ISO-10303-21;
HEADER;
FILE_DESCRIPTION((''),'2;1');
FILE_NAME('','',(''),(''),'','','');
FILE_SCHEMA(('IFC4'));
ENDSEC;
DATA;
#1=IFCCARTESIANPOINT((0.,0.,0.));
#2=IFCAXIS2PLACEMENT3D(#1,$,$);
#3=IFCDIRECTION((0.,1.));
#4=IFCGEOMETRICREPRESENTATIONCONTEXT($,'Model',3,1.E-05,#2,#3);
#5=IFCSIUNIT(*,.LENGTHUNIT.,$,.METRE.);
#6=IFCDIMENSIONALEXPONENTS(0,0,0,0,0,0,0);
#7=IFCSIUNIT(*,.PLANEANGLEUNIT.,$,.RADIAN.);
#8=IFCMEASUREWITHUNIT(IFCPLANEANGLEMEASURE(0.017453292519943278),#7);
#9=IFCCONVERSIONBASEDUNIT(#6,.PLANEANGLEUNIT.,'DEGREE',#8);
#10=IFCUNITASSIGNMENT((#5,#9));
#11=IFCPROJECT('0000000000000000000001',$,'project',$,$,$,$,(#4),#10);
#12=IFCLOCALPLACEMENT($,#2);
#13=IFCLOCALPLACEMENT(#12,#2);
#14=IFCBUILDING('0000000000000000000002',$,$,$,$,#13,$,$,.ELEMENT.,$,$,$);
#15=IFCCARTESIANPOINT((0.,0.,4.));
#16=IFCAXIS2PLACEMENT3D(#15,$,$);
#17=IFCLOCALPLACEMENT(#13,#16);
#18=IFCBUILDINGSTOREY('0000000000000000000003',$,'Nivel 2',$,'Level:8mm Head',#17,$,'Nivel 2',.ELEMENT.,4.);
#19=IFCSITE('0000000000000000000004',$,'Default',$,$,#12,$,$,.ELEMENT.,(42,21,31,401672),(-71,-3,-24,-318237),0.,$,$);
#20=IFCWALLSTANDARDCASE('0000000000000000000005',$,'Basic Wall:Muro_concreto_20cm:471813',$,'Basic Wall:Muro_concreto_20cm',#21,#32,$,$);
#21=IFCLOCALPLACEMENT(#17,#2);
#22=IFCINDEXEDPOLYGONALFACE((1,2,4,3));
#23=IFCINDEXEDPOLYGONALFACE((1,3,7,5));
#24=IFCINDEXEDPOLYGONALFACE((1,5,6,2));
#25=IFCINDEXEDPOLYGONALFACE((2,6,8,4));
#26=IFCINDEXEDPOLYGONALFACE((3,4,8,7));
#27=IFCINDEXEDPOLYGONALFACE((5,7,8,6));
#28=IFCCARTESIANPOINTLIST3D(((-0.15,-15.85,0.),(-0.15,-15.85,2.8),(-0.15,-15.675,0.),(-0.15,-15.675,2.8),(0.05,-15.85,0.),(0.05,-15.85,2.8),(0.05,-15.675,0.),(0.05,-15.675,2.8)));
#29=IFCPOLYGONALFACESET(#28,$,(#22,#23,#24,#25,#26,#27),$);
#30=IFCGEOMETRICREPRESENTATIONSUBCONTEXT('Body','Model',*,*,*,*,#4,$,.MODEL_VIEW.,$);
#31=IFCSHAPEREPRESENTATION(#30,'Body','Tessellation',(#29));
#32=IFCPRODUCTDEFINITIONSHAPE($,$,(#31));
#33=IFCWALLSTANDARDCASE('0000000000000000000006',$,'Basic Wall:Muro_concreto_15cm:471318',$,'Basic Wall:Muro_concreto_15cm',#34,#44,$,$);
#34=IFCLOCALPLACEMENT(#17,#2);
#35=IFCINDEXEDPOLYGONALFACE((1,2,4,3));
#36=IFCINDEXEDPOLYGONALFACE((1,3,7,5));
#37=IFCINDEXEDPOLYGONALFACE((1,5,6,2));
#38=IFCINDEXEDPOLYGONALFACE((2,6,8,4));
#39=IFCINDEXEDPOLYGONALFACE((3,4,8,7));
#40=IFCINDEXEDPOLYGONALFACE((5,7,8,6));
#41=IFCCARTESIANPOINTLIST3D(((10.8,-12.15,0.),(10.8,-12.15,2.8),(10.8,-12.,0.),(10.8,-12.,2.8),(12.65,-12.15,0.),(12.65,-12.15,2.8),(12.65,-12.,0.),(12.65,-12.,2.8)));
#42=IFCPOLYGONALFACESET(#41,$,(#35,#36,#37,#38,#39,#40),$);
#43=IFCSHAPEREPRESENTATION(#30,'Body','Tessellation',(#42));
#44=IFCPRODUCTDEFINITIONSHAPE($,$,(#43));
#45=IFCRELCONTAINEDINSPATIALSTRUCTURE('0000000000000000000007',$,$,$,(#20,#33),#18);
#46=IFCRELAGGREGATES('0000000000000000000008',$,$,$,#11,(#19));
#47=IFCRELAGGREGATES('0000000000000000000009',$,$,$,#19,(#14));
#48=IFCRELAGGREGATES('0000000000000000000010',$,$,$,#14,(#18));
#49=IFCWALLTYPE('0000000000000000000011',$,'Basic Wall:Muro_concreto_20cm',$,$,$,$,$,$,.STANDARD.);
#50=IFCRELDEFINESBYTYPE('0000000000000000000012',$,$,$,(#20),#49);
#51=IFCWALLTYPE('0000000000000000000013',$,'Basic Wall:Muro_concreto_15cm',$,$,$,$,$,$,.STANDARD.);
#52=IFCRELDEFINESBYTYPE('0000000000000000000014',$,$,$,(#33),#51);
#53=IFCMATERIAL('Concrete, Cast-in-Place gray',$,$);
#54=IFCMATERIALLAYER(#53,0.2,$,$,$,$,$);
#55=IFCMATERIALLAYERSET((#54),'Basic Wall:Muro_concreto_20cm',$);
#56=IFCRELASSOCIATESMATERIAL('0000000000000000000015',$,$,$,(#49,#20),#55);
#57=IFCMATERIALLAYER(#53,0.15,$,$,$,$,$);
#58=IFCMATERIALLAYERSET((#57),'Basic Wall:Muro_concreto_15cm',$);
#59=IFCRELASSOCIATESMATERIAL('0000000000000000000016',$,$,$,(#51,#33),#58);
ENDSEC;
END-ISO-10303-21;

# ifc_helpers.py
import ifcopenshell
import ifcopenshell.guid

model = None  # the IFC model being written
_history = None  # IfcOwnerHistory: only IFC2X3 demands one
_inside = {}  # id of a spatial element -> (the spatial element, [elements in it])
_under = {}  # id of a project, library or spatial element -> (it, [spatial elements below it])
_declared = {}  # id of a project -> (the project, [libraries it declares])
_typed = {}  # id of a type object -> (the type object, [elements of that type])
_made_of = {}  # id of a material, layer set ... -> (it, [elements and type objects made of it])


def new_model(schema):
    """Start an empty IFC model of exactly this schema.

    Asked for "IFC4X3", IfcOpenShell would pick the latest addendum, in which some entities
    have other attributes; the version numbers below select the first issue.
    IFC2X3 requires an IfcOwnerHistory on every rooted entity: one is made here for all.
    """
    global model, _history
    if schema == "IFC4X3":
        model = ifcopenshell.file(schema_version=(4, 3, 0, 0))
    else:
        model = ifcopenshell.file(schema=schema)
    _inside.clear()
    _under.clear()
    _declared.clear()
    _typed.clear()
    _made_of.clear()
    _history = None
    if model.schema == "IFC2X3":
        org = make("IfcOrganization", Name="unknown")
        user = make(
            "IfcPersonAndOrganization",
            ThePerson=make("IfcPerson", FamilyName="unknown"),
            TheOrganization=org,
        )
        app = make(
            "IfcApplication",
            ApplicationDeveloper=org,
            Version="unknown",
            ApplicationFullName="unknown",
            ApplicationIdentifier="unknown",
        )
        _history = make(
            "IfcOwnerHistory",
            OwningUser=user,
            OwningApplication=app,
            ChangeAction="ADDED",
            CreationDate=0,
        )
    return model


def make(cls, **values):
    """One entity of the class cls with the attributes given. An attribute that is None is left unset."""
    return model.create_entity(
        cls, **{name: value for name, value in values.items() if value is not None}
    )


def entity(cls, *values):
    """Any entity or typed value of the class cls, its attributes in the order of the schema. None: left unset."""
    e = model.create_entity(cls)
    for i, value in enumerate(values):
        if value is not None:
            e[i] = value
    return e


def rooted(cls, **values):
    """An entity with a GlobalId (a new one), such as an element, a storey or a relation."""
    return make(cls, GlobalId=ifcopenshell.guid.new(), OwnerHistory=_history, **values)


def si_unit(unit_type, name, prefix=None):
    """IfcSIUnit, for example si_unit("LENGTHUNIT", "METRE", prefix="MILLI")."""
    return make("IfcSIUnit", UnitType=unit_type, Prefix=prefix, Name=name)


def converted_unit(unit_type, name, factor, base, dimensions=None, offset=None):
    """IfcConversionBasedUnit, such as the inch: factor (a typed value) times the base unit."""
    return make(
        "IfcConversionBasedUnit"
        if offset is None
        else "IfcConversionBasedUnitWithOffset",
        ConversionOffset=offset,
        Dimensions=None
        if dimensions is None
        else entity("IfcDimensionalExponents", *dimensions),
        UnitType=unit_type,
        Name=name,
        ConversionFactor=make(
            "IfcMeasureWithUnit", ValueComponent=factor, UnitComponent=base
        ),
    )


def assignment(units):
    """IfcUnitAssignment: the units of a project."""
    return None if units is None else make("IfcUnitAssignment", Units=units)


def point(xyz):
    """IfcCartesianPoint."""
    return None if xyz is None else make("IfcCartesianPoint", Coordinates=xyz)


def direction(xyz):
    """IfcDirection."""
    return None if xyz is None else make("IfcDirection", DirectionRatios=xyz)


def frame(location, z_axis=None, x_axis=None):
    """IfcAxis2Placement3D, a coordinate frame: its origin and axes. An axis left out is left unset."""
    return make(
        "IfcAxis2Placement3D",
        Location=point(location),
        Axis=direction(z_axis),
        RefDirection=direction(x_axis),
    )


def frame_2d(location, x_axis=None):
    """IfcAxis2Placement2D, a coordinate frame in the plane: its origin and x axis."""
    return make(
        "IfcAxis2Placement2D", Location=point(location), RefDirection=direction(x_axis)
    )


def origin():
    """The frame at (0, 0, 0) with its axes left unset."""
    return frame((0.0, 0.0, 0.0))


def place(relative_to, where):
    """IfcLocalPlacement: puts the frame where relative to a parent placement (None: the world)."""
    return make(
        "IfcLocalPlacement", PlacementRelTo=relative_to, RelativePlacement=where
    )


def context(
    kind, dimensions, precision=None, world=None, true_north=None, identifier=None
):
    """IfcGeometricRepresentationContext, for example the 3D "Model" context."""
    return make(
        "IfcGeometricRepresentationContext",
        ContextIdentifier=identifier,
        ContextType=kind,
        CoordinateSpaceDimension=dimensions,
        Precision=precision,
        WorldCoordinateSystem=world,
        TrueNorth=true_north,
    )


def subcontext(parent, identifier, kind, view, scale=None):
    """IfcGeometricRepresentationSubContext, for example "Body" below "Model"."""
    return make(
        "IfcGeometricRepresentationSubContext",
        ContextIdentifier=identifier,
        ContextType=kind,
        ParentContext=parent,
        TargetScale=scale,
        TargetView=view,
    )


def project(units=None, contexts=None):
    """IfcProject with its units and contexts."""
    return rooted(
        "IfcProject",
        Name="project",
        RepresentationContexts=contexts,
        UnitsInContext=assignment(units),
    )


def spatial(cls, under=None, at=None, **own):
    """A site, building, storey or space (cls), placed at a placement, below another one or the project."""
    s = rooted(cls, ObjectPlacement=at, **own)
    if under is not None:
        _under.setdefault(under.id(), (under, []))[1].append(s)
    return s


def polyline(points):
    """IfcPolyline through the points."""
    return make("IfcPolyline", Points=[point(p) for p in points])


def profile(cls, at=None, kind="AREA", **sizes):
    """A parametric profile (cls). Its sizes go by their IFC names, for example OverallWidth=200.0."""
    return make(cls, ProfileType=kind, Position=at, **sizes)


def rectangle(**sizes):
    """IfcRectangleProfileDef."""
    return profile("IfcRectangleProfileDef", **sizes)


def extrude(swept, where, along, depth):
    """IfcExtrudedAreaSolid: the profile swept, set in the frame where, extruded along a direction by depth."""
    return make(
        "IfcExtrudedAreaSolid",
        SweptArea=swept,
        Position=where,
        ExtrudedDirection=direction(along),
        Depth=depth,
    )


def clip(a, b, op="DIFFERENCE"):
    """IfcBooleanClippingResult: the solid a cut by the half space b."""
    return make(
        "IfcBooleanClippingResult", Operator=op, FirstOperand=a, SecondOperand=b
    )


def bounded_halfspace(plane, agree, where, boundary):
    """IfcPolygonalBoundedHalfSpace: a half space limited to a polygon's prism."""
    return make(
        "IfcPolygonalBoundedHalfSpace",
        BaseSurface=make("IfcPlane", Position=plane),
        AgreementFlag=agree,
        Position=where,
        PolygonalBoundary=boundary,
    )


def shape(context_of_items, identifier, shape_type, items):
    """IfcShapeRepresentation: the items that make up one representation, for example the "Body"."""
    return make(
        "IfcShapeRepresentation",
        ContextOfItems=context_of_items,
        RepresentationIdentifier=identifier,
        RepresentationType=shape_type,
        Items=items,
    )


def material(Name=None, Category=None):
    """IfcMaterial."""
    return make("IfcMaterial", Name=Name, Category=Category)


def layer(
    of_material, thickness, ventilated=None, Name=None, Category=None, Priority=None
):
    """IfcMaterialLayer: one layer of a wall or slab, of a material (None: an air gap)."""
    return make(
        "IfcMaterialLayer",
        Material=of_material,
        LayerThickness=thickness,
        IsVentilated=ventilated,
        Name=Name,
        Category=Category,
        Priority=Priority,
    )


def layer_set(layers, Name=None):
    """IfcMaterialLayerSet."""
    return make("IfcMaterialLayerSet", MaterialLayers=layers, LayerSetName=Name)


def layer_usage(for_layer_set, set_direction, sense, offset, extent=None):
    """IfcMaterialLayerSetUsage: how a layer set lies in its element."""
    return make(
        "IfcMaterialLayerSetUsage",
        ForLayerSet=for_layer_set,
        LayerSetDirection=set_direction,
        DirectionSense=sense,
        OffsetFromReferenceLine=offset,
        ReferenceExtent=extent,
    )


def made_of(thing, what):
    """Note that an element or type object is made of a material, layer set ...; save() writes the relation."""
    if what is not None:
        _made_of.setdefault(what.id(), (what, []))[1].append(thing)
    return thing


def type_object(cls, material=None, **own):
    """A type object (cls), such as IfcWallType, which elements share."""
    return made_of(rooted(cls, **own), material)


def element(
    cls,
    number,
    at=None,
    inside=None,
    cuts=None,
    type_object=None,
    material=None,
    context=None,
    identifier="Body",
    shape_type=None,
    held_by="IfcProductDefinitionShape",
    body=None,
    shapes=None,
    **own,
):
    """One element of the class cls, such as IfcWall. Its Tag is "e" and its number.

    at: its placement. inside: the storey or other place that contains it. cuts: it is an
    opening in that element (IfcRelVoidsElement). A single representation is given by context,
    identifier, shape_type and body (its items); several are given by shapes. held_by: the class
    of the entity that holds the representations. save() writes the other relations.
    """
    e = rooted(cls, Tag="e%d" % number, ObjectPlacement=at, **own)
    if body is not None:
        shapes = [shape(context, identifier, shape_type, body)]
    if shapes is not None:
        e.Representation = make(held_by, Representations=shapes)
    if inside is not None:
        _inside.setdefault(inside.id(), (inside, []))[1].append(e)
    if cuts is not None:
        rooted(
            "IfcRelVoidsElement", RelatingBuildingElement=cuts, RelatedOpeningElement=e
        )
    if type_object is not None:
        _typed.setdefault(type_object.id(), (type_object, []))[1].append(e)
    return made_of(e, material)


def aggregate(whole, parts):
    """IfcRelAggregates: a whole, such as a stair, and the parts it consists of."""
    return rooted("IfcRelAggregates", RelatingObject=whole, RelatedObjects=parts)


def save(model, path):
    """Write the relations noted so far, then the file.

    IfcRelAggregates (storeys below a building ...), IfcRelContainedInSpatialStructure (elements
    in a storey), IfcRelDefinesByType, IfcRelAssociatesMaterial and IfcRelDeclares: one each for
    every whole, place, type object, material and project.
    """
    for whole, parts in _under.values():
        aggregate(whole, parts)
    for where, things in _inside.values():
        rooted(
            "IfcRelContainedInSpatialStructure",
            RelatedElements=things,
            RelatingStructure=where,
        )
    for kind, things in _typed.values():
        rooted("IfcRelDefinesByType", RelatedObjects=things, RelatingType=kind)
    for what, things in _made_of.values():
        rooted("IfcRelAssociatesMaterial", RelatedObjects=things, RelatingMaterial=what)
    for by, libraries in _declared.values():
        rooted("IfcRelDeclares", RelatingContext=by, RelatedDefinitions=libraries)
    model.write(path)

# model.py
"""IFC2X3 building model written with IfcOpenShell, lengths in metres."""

from ifc_helpers import new_model, entity, si_unit, converted_unit, direction, frame, frame_2d, origin, place, context, subcontext, project, spatial, polyline, rectangle, extrude, clip, bounded_halfspace, material, layer, layer_set, layer_usage, type_object, element, save


model = new_model("IFC2X3")

# Units and contexts
model_context = context("Model", 3, precision=1e-05, world=origin(), true_north=direction((0.0, 1.0)))
body_context = subcontext(model_context, "Body", "Model", "MODEL_VIEW")
ifc_project = project(units=[si_unit("LENGTHUNIT", "METRE"), converted_unit("PLANEANGLEUNIT", "DEGREE", entity("IfcPlaneAngleMeasure", 0.017453292519943278), si_unit("PLANEANGLEUNIT", "RADIAN"), dimensions=[0, 0, 0, 0, 0, 0, 0])], contexts=[model_context])

# Site, building, storey
site_placement = place(None, origin())
site = spatial("IfcSite", under=ifc_project, at=site_placement, Name="Default", CompositionType="ELEMENT", RefLatitude=(42, 21, 31, 401672), RefLongitude=(-71, -3, -24, -318237), RefElevation=0.0)
building_placement = place(site_placement, origin())
building = spatial("IfcBuilding", under=site, at=building_placement, CompositionType="ELEMENT")
storey_placement = place(building_placement, frame((0.0, 0.0, 4.0)))
storey = spatial("IfcBuildingStorey", under=building, at=storey_placement, Name="Nivel 2", ObjectType="Level:8mm Head", LongName="Nivel 2", CompositionType="ELEMENT", Elevation=4.0)

# Shared definitions
ifc_material_1 = material(Name="Concrete, Cast-in-Place gray")

# Walls
ifc_layer_1 = layer(ifc_material_1, 0.2)
ifc_layer_set_1 = layer_set([ifc_layer_1], Name="Basic Wall:Muro_concreto_20cm")
wall_type_1 = type_object("IfcWallType", Name="Basic Wall:Muro_concreto_20cm", PredefinedType="STANDARD", material=ifc_layer_set_1)
ifc_layer_usage_1 = layer_usage(ifc_layer_set_1, "AXIS2", "NEGATIVE", 0.1)
wall_1_placement = place(storey_placement, frame((-0.05, -15.675, 0.0), z_axis=(0.0, 0.0, 1.0), x_axis=(0.0, -1.0, 0.0)))
element("IfcWallStandardCase", 1, at=wall_1_placement, inside=storey, type_object=wall_type_1, material=ifc_layer_usage_1, Name="Basic Wall:Muro_concreto_20cm:471813", ObjectType="Basic Wall:Muro_concreto_20cm", context=body_context, shape_type="Clipping", body=[
    clip(extrude(rectangle(XDim=0.175, YDim=0.2, at=frame_2d((0.0875, 0.0), x_axis=(-1.0, 0.0))), origin(), (0.0, 0.0, 1.0), 2.8), bounded_halfspace(frame((0.0, -0.1, 2.8), z_axis=(0.0, 0.0, -1.0), x_axis=(1.0, 0.0, 0.0)), True, frame((0.0, -0.1, 2.8)), polyline([(0.0, 0.0), (0.175, 0.0), (0.175, 0.2), (0.0, 0.2), (0.0, 0.0)]))),
])
ifc_layer_2 = layer(ifc_material_1, 0.15)
ifc_layer_set_2 = layer_set([ifc_layer_2], Name="Basic Wall:Muro_concreto_15cm")
ifc_layer_usage_2 = layer_usage(ifc_layer_set_2, "AXIS2", "NEGATIVE", 0.075)
wall_type_2 = type_object("IfcWallType", Name="Basic Wall:Muro_concreto_15cm", PredefinedType="STANDARD", material=ifc_layer_set_2)
wall_2_placement = place(storey_placement, frame((10.8, -12.075, 0.0)))
element("IfcWallStandardCase", 2, at=wall_2_placement, inside=storey, type_object=wall_type_2, material=ifc_layer_usage_2, Name="Basic Wall:Muro_concreto_15cm:471318", ObjectType="Basic Wall:Muro_concreto_15cm", context=body_context, shape_type="Clipping", body=[
    clip(extrude(rectangle(XDim=1.85, YDim=0.15, at=frame_2d((0.925, 0.0), x_axis=(-1.0, 0.0))), origin(), (0.0, 0.0, 1.0), 2.8), bounded_halfspace(frame((0.0, -0.075, 2.8), z_axis=(0.0, 0.0, -1.0), x_axis=(0.0, -1.0, 0.0)), True, frame((0.0, -0.075, 2.8)), polyline([(0.0, 0.0), (1.85, 0.0), (1.85, 0.15), (1.55, 0.15), (0.0, 0.15), (0.0, 0.0)]))),
])

save(model, "model.ifc")
